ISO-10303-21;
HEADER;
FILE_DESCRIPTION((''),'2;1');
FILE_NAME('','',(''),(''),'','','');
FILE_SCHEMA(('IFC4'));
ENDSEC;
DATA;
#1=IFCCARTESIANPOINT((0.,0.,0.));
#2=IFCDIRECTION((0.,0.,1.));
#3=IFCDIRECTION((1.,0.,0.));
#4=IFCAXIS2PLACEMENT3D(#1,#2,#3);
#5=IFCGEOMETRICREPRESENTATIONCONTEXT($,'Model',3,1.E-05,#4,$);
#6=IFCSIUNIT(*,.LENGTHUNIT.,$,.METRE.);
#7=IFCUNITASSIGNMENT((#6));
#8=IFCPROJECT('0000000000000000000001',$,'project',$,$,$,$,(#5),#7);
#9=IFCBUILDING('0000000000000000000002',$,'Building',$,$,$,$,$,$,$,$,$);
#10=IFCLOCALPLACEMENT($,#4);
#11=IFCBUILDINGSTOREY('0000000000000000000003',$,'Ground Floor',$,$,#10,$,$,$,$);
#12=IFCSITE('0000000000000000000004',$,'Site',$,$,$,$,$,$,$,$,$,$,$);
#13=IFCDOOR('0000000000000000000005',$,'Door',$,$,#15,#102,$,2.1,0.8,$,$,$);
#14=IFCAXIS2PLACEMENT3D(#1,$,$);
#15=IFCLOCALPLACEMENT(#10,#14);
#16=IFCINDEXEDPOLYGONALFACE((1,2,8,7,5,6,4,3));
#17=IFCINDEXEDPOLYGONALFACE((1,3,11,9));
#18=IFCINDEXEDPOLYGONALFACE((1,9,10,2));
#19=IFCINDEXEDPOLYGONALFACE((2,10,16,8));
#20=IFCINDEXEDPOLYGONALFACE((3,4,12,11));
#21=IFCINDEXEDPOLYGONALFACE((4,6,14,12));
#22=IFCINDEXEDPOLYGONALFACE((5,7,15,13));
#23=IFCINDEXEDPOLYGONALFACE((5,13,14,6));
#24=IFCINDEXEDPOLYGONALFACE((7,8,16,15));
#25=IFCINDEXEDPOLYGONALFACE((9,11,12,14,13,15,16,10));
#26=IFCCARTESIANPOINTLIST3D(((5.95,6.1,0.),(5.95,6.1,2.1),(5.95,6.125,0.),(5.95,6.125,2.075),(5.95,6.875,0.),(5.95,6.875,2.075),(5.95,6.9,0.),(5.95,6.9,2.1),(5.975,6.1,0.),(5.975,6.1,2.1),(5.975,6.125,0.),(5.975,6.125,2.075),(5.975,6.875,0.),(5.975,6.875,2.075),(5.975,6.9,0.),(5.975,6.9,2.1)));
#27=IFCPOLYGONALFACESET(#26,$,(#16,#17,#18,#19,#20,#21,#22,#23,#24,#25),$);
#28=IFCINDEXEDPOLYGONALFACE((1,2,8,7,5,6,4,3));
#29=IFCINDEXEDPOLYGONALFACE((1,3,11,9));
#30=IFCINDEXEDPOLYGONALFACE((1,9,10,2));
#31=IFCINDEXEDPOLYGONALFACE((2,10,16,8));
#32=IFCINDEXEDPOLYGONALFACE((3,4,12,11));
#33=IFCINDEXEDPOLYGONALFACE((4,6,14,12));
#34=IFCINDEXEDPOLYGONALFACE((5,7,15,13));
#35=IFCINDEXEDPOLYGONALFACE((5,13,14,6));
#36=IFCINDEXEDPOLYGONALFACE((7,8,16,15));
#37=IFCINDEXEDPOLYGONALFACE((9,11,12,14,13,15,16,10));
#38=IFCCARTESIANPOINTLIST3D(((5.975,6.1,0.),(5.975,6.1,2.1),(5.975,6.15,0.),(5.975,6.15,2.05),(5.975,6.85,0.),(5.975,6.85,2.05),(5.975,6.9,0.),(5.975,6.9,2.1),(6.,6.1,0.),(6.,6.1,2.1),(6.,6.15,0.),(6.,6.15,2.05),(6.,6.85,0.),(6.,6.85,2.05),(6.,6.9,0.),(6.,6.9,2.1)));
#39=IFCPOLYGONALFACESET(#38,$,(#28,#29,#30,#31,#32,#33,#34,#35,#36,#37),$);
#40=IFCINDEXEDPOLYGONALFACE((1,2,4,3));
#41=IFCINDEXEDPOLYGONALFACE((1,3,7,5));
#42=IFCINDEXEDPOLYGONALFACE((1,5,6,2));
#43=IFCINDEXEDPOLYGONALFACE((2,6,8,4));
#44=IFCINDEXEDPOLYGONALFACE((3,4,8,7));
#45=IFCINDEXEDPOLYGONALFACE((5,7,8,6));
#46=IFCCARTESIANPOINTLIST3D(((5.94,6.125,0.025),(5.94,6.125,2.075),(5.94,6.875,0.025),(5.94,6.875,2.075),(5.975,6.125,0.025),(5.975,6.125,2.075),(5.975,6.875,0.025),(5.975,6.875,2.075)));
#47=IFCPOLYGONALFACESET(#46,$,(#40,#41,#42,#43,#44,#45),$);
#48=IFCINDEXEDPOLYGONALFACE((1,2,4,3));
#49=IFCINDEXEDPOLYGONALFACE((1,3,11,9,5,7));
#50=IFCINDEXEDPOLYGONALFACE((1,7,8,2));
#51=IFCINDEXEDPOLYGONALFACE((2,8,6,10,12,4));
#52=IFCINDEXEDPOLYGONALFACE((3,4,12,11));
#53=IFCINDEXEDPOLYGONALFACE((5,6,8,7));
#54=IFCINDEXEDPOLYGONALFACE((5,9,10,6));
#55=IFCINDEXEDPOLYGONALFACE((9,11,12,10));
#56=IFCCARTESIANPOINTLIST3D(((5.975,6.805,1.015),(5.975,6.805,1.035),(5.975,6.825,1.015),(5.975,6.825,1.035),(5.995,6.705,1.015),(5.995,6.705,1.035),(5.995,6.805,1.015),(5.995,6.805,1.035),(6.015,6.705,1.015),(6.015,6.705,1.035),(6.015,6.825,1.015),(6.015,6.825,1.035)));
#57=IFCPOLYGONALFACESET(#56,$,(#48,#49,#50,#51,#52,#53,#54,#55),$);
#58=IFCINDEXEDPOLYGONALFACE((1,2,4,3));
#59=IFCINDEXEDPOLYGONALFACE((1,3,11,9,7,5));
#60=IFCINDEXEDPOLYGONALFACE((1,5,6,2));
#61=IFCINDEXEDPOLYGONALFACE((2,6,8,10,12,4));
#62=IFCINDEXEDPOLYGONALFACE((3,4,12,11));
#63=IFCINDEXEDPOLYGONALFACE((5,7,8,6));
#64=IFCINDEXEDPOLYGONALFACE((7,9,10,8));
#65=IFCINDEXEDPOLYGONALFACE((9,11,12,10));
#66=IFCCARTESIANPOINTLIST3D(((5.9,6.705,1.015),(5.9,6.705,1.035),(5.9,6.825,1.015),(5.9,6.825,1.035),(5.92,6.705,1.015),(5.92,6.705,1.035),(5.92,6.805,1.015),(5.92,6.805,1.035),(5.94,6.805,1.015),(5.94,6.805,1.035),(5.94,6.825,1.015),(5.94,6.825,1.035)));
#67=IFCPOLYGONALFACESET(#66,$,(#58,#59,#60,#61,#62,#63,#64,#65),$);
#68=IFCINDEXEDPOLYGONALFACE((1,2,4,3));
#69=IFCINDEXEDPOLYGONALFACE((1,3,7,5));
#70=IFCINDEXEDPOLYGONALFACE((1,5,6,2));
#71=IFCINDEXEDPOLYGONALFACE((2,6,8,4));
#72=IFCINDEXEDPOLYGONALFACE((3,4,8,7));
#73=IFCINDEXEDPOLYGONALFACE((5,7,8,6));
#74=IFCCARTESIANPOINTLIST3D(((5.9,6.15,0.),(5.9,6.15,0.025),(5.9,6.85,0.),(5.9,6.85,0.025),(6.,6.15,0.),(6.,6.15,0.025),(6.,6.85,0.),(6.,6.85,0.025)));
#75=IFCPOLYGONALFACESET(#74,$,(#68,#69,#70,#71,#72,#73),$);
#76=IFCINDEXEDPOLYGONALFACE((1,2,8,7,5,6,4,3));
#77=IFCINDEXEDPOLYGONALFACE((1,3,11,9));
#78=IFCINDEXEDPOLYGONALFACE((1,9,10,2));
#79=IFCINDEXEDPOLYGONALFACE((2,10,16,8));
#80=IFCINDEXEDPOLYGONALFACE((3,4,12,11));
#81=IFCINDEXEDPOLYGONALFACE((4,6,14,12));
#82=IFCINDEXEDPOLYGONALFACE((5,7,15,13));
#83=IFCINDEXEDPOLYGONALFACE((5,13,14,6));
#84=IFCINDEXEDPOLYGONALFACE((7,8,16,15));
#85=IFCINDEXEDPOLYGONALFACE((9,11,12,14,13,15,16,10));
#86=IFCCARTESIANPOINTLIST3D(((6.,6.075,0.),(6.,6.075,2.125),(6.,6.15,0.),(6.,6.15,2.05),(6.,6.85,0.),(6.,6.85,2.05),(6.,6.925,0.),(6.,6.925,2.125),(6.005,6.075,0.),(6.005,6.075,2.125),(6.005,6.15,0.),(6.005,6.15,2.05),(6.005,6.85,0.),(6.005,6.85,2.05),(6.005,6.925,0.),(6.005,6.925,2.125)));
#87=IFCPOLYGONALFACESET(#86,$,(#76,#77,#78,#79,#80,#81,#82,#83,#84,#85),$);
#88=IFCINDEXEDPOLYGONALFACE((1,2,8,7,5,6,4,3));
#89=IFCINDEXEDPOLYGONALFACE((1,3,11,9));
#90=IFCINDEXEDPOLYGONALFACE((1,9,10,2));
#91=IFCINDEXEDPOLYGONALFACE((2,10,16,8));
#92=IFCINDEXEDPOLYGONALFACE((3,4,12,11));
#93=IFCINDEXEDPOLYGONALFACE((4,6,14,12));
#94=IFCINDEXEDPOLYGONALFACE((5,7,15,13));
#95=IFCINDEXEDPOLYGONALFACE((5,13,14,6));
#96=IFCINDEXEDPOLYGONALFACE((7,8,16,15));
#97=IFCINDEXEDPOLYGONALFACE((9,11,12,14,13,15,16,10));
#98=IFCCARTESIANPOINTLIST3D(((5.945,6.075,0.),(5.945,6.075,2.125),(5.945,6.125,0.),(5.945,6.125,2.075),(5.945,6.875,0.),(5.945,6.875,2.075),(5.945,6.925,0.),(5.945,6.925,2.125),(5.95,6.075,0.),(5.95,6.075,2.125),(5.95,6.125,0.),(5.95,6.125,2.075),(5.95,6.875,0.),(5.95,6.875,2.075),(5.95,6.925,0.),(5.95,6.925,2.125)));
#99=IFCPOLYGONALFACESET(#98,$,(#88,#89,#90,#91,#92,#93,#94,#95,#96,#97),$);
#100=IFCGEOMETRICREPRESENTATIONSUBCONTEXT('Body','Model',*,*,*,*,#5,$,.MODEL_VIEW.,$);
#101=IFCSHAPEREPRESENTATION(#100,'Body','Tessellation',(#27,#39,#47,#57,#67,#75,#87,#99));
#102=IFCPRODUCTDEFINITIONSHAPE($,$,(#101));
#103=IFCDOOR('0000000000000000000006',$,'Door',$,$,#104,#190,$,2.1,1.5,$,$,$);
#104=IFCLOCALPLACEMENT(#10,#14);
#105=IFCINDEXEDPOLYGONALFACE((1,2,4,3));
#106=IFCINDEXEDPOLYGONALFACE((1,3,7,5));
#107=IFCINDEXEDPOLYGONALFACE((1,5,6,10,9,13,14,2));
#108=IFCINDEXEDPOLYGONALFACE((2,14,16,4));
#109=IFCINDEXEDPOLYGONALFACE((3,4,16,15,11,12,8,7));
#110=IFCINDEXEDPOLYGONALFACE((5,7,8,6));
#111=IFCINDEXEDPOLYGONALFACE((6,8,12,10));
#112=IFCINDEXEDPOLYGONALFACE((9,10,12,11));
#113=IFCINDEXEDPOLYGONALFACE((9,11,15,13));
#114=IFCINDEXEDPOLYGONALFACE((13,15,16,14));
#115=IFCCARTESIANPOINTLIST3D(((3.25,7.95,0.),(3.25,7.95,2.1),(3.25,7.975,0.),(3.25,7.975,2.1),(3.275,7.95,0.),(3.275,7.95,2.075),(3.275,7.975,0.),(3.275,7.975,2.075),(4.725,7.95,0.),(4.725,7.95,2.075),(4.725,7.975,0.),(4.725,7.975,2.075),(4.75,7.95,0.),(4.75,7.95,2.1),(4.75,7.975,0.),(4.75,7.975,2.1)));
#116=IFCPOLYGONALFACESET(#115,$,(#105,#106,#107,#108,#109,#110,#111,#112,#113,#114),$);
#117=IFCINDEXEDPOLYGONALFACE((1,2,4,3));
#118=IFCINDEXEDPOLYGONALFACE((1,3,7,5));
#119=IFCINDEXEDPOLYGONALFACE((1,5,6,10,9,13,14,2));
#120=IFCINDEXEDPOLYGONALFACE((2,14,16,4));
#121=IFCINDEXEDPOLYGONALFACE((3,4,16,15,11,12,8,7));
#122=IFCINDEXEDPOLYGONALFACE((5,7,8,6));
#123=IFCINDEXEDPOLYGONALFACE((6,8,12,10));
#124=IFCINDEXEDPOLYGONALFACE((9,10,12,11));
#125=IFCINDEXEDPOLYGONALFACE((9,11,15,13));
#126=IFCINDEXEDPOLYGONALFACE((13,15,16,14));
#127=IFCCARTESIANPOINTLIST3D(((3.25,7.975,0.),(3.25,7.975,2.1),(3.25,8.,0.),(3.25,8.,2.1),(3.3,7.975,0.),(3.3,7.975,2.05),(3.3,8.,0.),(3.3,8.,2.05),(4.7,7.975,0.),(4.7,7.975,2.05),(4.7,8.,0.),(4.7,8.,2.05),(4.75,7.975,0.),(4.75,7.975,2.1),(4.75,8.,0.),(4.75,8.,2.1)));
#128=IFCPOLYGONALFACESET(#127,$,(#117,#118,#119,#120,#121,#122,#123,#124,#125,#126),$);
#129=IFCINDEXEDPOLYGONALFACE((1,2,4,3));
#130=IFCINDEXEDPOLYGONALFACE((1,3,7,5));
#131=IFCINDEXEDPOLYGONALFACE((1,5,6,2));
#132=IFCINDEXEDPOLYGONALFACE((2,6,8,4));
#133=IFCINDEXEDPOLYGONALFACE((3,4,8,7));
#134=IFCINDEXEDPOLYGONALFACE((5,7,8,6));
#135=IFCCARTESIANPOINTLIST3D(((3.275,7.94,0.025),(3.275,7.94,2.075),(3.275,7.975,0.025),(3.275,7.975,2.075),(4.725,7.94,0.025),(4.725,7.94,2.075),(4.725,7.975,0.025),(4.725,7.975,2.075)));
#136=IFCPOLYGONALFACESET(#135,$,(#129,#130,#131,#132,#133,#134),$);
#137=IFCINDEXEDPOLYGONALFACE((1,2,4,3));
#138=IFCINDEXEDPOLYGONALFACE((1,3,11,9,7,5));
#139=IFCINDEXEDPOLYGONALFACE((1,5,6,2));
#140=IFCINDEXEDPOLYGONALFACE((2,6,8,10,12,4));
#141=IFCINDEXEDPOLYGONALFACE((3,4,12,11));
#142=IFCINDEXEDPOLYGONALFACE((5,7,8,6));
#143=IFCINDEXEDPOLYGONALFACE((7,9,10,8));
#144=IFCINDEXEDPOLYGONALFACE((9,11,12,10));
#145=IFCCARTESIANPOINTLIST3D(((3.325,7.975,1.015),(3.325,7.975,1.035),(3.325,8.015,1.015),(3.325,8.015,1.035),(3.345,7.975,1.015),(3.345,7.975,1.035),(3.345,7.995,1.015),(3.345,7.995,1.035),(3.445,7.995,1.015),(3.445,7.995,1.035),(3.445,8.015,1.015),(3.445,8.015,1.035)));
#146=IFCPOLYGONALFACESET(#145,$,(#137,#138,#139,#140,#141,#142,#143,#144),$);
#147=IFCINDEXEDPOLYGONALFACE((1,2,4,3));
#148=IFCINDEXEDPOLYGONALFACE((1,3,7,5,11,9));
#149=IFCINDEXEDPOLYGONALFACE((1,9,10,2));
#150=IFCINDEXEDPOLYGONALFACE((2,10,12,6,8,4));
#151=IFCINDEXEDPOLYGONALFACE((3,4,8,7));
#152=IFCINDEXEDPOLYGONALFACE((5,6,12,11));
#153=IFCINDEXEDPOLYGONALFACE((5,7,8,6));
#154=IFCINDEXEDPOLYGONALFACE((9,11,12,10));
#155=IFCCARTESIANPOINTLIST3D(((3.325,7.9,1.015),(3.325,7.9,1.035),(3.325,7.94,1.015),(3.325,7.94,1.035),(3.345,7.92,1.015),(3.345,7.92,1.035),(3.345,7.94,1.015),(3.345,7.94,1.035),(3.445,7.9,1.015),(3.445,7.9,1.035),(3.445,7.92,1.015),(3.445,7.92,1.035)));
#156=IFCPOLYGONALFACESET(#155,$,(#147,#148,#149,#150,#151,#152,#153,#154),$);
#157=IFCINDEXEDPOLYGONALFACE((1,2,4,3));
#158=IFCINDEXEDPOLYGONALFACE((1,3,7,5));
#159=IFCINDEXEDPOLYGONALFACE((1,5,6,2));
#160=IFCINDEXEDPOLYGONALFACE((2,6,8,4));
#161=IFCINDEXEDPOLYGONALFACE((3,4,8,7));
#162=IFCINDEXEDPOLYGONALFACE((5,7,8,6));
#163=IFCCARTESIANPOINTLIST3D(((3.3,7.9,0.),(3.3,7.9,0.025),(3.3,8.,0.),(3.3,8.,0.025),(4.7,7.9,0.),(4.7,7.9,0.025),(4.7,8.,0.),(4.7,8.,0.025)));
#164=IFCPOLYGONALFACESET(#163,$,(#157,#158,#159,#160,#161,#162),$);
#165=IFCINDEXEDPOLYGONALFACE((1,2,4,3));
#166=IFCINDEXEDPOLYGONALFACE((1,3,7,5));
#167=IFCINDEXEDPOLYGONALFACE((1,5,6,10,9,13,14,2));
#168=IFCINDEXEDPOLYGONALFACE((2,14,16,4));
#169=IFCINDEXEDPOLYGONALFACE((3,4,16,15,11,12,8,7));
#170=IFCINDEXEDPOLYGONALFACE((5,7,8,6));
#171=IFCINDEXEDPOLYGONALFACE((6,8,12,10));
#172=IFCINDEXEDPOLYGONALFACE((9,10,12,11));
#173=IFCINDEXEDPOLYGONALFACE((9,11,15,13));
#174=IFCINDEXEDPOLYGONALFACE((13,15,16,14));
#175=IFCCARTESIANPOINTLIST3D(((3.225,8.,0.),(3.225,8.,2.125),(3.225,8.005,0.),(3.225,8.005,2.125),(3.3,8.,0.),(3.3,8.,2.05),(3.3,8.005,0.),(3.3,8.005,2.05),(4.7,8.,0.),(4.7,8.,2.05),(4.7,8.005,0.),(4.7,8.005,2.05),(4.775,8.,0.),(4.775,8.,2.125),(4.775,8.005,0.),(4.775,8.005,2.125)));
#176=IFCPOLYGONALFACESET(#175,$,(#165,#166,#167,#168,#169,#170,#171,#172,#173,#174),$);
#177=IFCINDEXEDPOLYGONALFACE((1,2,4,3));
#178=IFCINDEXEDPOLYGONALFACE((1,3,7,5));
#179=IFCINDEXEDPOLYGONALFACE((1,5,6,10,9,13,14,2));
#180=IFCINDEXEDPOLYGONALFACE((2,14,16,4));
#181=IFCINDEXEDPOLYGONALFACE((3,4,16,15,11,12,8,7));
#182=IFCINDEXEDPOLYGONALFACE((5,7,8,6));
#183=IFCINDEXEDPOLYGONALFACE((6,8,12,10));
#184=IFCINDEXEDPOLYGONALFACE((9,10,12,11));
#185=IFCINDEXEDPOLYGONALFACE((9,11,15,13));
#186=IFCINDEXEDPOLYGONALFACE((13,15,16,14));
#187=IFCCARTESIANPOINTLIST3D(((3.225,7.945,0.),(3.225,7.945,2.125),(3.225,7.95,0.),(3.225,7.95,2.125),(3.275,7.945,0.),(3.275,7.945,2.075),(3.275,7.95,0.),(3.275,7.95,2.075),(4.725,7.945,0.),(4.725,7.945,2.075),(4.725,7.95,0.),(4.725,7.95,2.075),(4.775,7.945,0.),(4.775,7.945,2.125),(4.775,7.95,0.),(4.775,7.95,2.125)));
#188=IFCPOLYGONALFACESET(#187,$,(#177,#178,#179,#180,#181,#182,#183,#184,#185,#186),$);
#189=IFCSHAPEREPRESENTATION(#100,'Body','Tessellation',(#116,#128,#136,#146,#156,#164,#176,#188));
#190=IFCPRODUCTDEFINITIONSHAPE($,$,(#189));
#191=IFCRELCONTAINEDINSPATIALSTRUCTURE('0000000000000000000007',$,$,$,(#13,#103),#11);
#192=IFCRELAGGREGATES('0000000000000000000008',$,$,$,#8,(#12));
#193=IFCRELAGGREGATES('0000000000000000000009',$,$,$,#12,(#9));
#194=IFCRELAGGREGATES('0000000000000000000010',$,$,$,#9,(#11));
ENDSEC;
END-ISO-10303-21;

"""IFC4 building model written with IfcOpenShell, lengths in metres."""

from ifc_helpers import new_model, si_unit, frame, origin_with_axes, place, context, subcontext, project, spatial, line, indexed_curve, outline, extrude, element, save


model = new_model("IFC4")

# Units and contexts
model_context = context("Model", 3, precision=1e-05, world=origin_with_axes())
body_context = subcontext(model_context, "Body", "Model", "MODEL_VIEW")
ifc_project = project(units=[si_unit("LENGTHUNIT", "METRE")], contexts=[model_context])

# Site, building, storey
site = spatial("IfcSite", under=ifc_project, Name="Site")
building = spatial("IfcBuilding", under=site, Name="Building")
storey_placement = place(None, origin_with_axes())
storey = spatial("IfcBuildingStorey", under=building, at=storey_placement, Name="Ground Floor")

# Doors
door_1_placement = place(storey_placement, frame((6.0, 6.1, 0.0), z_axis=(0.0, 0.0, 1.0), x_axis=(0.0, 1.0, 0.0)))
element("IfcDoor", 1, at=door_1_placement, inside=storey, Name="Door", OverallHeight=2.1, OverallWidth=0.8, context=body_context, shape_type="SweptSolid", body=[
    extrude(outline(indexed_curve([(0.0, 0.0), (0.0, 2.1), (0.8, 2.1), (0.8, 0.0), (0.775, 0.0), (0.775, 2.075), (0.025, 2.075), (0.025, 0.0)], segments=[line(1, 2, 3, 4, 5, 6, 7, 8, 1)])), frame((0.0, 0.025, 0.0), z_axis=(0.0, -1.0, 0.0), x_axis=(1.0, 0.0, 0.0)), (0.0, 0.0, -1.0), 0.025),
    extrude(outline(indexed_curve([(0.0, 0.0), (0.0, 2.1), (0.8, 2.1), (0.8, 0.0), (0.75, 0.0), (0.75, 2.05), (0.05, 2.05), (0.05, 0.0)], segments=[line(1, 2, 3, 4, 5, 6, 7, 8, 1)])), frame((0.0, 0.0, 0.0), z_axis=(0.0, -1.0, 0.0), x_axis=(1.0, 0.0, 0.0)), (0.0, 0.0, -1.0), 0.025),
    extrude(outline(indexed_curve([(0.0, 0.0), (0.75, 0.0), (0.75, 0.035), (0.0, 0.035)], segments=[line(1, 2, 3, 4, 1)])), frame((0.025, 0.025, 0.025), z_axis=(0.0, 0.0, 1.0), x_axis=(1.0, 0.0, 0.0)), (0.0, 0.0, 1.0), 2.05),
    extrude(outline(indexed_curve([(0.0, 0.0), (0.0, -0.04), (-0.12, -0.04), (-0.12, -0.02), (-0.02, -0.02), (-0.02, 0.0)], segments=[line(1, 2, 3, 4, 5, 6, 1)])), frame((0.725, 0.025, 1.015), z_axis=(0.0, 0.0, 1.0), x_axis=(1.0, 0.0, 0.0)), (0.0, 0.0, 1.0), 0.02),
    extrude(outline(indexed_curve([(0.0, 0.0), (0.0, 0.04), (-0.12, 0.04), (-0.12, 0.02), (-0.02, 0.02), (-0.02, 0.0)], segments=[line(1, 2, 3, 4, 5, 6, 1)])), frame((0.725, 0.06, 1.015), z_axis=(0.0, 0.0, 1.0), x_axis=(1.0, 0.0, 0.0)), (0.0, 0.0, 1.0), 0.02),
    extrude(outline(indexed_curve([(0.0, 0.0), (0.7, 0.0), (0.7, 0.1), (0.0, 0.1)], segments=[line(1, 2, 3, 4, 1)])), frame((0.05, 0.0, 0.0), z_axis=(0.0, 0.0, 1.0), x_axis=(1.0, 0.0, 0.0)), (0.0, 0.0, 1.0), 0.025),
    extrude(outline(indexed_curve([(0.0, 0.0), (0.0, 2.125), (0.85, 2.125), (0.85, 0.0), (0.775, 0.0), (0.775, 2.05), (0.075, 2.05), (0.075, 0.0)], segments=[line(1, 2, 3, 4, 5, 6, 7, 8, 1)])), frame((-0.025, -0.005, 0.0), z_axis=(0.0, -1.0, 0.0), x_axis=(1.0, 0.0, 0.0)), (0.0, 0.0, -1.0), 0.005),
    extrude(outline(indexed_curve([(0.0, 0.0), (0.0, 2.125), (0.85, 2.125), (0.85, 0.0), (0.8, 0.0), (0.8, 2.075), (0.05, 2.075), (0.05, 0.0)], segments=[line(1, 2, 3, 4, 5, 6, 7, 8, 1)])), frame((-0.025, 0.05, 0.0), z_axis=(0.0, -1.0, 0.0), x_axis=(1.0, 0.0, 0.0)), (0.0, 0.0, -1.0), 0.005),
])
door_2_placement = place(storey_placement, frame((4.75, 8.0, 0.0), z_axis=(0.0, 0.0, 1.0), x_axis=(-1.0, 0.0, 0.0)))
element("IfcDoor", 2, at=door_2_placement, inside=storey, Name="Door", OverallHeight=2.1, OverallWidth=1.5, context=body_context, shape_type="SweptSolid", body=[
    extrude(outline(indexed_curve([(0.0, 0.0), (0.0, 2.1), (1.5, 2.1), (1.5, 0.0), (1.475, 0.0), (1.475, 2.075), (0.025, 2.075), (0.025, 0.0)], segments=[line(1, 2, 3, 4, 5, 6, 7, 8, 1)])), frame((0.0, 0.025, 0.0), z_axis=(0.0, -1.0, 0.0), x_axis=(1.0, 0.0, 0.0)), (0.0, 0.0, -1.0), 0.025),
    extrude(outline(indexed_curve([(0.0, 0.0), (0.0, 2.1), (1.5, 2.1), (1.5, 0.0), (1.45, 0.0), (1.45, 2.05), (0.05, 2.05), (0.05, 0.0)], segments=[line(1, 2, 3, 4, 5, 6, 7, 8, 1)])), frame((0.0, 0.0, 0.0), z_axis=(0.0, -1.0, 0.0), x_axis=(1.0, 0.0, 0.0)), (0.0, 0.0, -1.0), 0.025),
    extrude(outline(indexed_curve([(0.0, 0.0), (1.45, 0.0), (1.45, 0.035), (0.0, 0.035)], segments=[line(1, 2, 3, 4, 1)])), frame((0.025, 0.025, 0.025), z_axis=(0.0, 0.0, 1.0), x_axis=(1.0, 0.0, 0.0)), (0.0, 0.0, 1.0), 2.05),
    extrude(outline(indexed_curve([(0.0, 0.0), (0.0, -0.04), (-0.12, -0.04), (-0.12, -0.02), (-0.02, -0.02), (-0.02, 0.0)], segments=[line(1, 2, 3, 4, 5, 6, 1)])), frame((1.425, 0.025, 1.015), z_axis=(0.0, 0.0, 1.0), x_axis=(1.0, 0.0, 0.0)), (0.0, 0.0, 1.0), 0.02),
    extrude(outline(indexed_curve([(0.0, 0.0), (0.0, 0.04), (-0.12, 0.04), (-0.12, 0.02), (-0.02, 0.02), (-0.02, 0.0)], segments=[line(1, 2, 3, 4, 5, 6, 1)])), frame((1.425, 0.06, 1.015), z_axis=(0.0, 0.0, 1.0), x_axis=(1.0, 0.0, 0.0)), (0.0, 0.0, 1.0), 0.02),
    extrude(outline(indexed_curve([(0.0, 0.0), (1.4, 0.0), (1.4, 0.1), (0.0, 0.1)], segments=[line(1, 2, 3, 4, 1)])), frame((0.05, 0.0, 0.0), z_axis=(0.0, 0.0, 1.0), x_axis=(1.0, 0.0, 0.0)), (0.0, 0.0, 1.0), 0.025),
    extrude(outline(indexed_curve([(0.0, 0.0), (0.0, 2.125), (1.55, 2.125), (1.55, 0.0), (1.475, 0.0), (1.475, 2.05), (0.075, 2.05), (0.075, 0.0)], segments=[line(1, 2, 3, 4, 5, 6, 7, 8, 1)])), frame((-0.025, -0.005, 0.0), z_axis=(0.0, -1.0, 0.0), x_axis=(1.0, 0.0, 0.0)), (0.0, 0.0, -1.0), 0.005),
    extrude(outline(indexed_curve([(0.0, 0.0), (0.0, 2.125), (1.55, 2.125), (1.55, 0.0), (1.5, 0.0), (1.5, 2.075), (0.05, 2.075), (0.05, 0.0)], segments=[line(1, 2, 3, 4, 5, 6, 7, 8, 1)])), frame((-0.025, 0.05, 0.0), z_axis=(0.0, -1.0, 0.0), x_axis=(1.0, 0.0, 0.0)), (0.0, 0.0, -1.0), 0.005),
])

save(model, "model.ifc")
